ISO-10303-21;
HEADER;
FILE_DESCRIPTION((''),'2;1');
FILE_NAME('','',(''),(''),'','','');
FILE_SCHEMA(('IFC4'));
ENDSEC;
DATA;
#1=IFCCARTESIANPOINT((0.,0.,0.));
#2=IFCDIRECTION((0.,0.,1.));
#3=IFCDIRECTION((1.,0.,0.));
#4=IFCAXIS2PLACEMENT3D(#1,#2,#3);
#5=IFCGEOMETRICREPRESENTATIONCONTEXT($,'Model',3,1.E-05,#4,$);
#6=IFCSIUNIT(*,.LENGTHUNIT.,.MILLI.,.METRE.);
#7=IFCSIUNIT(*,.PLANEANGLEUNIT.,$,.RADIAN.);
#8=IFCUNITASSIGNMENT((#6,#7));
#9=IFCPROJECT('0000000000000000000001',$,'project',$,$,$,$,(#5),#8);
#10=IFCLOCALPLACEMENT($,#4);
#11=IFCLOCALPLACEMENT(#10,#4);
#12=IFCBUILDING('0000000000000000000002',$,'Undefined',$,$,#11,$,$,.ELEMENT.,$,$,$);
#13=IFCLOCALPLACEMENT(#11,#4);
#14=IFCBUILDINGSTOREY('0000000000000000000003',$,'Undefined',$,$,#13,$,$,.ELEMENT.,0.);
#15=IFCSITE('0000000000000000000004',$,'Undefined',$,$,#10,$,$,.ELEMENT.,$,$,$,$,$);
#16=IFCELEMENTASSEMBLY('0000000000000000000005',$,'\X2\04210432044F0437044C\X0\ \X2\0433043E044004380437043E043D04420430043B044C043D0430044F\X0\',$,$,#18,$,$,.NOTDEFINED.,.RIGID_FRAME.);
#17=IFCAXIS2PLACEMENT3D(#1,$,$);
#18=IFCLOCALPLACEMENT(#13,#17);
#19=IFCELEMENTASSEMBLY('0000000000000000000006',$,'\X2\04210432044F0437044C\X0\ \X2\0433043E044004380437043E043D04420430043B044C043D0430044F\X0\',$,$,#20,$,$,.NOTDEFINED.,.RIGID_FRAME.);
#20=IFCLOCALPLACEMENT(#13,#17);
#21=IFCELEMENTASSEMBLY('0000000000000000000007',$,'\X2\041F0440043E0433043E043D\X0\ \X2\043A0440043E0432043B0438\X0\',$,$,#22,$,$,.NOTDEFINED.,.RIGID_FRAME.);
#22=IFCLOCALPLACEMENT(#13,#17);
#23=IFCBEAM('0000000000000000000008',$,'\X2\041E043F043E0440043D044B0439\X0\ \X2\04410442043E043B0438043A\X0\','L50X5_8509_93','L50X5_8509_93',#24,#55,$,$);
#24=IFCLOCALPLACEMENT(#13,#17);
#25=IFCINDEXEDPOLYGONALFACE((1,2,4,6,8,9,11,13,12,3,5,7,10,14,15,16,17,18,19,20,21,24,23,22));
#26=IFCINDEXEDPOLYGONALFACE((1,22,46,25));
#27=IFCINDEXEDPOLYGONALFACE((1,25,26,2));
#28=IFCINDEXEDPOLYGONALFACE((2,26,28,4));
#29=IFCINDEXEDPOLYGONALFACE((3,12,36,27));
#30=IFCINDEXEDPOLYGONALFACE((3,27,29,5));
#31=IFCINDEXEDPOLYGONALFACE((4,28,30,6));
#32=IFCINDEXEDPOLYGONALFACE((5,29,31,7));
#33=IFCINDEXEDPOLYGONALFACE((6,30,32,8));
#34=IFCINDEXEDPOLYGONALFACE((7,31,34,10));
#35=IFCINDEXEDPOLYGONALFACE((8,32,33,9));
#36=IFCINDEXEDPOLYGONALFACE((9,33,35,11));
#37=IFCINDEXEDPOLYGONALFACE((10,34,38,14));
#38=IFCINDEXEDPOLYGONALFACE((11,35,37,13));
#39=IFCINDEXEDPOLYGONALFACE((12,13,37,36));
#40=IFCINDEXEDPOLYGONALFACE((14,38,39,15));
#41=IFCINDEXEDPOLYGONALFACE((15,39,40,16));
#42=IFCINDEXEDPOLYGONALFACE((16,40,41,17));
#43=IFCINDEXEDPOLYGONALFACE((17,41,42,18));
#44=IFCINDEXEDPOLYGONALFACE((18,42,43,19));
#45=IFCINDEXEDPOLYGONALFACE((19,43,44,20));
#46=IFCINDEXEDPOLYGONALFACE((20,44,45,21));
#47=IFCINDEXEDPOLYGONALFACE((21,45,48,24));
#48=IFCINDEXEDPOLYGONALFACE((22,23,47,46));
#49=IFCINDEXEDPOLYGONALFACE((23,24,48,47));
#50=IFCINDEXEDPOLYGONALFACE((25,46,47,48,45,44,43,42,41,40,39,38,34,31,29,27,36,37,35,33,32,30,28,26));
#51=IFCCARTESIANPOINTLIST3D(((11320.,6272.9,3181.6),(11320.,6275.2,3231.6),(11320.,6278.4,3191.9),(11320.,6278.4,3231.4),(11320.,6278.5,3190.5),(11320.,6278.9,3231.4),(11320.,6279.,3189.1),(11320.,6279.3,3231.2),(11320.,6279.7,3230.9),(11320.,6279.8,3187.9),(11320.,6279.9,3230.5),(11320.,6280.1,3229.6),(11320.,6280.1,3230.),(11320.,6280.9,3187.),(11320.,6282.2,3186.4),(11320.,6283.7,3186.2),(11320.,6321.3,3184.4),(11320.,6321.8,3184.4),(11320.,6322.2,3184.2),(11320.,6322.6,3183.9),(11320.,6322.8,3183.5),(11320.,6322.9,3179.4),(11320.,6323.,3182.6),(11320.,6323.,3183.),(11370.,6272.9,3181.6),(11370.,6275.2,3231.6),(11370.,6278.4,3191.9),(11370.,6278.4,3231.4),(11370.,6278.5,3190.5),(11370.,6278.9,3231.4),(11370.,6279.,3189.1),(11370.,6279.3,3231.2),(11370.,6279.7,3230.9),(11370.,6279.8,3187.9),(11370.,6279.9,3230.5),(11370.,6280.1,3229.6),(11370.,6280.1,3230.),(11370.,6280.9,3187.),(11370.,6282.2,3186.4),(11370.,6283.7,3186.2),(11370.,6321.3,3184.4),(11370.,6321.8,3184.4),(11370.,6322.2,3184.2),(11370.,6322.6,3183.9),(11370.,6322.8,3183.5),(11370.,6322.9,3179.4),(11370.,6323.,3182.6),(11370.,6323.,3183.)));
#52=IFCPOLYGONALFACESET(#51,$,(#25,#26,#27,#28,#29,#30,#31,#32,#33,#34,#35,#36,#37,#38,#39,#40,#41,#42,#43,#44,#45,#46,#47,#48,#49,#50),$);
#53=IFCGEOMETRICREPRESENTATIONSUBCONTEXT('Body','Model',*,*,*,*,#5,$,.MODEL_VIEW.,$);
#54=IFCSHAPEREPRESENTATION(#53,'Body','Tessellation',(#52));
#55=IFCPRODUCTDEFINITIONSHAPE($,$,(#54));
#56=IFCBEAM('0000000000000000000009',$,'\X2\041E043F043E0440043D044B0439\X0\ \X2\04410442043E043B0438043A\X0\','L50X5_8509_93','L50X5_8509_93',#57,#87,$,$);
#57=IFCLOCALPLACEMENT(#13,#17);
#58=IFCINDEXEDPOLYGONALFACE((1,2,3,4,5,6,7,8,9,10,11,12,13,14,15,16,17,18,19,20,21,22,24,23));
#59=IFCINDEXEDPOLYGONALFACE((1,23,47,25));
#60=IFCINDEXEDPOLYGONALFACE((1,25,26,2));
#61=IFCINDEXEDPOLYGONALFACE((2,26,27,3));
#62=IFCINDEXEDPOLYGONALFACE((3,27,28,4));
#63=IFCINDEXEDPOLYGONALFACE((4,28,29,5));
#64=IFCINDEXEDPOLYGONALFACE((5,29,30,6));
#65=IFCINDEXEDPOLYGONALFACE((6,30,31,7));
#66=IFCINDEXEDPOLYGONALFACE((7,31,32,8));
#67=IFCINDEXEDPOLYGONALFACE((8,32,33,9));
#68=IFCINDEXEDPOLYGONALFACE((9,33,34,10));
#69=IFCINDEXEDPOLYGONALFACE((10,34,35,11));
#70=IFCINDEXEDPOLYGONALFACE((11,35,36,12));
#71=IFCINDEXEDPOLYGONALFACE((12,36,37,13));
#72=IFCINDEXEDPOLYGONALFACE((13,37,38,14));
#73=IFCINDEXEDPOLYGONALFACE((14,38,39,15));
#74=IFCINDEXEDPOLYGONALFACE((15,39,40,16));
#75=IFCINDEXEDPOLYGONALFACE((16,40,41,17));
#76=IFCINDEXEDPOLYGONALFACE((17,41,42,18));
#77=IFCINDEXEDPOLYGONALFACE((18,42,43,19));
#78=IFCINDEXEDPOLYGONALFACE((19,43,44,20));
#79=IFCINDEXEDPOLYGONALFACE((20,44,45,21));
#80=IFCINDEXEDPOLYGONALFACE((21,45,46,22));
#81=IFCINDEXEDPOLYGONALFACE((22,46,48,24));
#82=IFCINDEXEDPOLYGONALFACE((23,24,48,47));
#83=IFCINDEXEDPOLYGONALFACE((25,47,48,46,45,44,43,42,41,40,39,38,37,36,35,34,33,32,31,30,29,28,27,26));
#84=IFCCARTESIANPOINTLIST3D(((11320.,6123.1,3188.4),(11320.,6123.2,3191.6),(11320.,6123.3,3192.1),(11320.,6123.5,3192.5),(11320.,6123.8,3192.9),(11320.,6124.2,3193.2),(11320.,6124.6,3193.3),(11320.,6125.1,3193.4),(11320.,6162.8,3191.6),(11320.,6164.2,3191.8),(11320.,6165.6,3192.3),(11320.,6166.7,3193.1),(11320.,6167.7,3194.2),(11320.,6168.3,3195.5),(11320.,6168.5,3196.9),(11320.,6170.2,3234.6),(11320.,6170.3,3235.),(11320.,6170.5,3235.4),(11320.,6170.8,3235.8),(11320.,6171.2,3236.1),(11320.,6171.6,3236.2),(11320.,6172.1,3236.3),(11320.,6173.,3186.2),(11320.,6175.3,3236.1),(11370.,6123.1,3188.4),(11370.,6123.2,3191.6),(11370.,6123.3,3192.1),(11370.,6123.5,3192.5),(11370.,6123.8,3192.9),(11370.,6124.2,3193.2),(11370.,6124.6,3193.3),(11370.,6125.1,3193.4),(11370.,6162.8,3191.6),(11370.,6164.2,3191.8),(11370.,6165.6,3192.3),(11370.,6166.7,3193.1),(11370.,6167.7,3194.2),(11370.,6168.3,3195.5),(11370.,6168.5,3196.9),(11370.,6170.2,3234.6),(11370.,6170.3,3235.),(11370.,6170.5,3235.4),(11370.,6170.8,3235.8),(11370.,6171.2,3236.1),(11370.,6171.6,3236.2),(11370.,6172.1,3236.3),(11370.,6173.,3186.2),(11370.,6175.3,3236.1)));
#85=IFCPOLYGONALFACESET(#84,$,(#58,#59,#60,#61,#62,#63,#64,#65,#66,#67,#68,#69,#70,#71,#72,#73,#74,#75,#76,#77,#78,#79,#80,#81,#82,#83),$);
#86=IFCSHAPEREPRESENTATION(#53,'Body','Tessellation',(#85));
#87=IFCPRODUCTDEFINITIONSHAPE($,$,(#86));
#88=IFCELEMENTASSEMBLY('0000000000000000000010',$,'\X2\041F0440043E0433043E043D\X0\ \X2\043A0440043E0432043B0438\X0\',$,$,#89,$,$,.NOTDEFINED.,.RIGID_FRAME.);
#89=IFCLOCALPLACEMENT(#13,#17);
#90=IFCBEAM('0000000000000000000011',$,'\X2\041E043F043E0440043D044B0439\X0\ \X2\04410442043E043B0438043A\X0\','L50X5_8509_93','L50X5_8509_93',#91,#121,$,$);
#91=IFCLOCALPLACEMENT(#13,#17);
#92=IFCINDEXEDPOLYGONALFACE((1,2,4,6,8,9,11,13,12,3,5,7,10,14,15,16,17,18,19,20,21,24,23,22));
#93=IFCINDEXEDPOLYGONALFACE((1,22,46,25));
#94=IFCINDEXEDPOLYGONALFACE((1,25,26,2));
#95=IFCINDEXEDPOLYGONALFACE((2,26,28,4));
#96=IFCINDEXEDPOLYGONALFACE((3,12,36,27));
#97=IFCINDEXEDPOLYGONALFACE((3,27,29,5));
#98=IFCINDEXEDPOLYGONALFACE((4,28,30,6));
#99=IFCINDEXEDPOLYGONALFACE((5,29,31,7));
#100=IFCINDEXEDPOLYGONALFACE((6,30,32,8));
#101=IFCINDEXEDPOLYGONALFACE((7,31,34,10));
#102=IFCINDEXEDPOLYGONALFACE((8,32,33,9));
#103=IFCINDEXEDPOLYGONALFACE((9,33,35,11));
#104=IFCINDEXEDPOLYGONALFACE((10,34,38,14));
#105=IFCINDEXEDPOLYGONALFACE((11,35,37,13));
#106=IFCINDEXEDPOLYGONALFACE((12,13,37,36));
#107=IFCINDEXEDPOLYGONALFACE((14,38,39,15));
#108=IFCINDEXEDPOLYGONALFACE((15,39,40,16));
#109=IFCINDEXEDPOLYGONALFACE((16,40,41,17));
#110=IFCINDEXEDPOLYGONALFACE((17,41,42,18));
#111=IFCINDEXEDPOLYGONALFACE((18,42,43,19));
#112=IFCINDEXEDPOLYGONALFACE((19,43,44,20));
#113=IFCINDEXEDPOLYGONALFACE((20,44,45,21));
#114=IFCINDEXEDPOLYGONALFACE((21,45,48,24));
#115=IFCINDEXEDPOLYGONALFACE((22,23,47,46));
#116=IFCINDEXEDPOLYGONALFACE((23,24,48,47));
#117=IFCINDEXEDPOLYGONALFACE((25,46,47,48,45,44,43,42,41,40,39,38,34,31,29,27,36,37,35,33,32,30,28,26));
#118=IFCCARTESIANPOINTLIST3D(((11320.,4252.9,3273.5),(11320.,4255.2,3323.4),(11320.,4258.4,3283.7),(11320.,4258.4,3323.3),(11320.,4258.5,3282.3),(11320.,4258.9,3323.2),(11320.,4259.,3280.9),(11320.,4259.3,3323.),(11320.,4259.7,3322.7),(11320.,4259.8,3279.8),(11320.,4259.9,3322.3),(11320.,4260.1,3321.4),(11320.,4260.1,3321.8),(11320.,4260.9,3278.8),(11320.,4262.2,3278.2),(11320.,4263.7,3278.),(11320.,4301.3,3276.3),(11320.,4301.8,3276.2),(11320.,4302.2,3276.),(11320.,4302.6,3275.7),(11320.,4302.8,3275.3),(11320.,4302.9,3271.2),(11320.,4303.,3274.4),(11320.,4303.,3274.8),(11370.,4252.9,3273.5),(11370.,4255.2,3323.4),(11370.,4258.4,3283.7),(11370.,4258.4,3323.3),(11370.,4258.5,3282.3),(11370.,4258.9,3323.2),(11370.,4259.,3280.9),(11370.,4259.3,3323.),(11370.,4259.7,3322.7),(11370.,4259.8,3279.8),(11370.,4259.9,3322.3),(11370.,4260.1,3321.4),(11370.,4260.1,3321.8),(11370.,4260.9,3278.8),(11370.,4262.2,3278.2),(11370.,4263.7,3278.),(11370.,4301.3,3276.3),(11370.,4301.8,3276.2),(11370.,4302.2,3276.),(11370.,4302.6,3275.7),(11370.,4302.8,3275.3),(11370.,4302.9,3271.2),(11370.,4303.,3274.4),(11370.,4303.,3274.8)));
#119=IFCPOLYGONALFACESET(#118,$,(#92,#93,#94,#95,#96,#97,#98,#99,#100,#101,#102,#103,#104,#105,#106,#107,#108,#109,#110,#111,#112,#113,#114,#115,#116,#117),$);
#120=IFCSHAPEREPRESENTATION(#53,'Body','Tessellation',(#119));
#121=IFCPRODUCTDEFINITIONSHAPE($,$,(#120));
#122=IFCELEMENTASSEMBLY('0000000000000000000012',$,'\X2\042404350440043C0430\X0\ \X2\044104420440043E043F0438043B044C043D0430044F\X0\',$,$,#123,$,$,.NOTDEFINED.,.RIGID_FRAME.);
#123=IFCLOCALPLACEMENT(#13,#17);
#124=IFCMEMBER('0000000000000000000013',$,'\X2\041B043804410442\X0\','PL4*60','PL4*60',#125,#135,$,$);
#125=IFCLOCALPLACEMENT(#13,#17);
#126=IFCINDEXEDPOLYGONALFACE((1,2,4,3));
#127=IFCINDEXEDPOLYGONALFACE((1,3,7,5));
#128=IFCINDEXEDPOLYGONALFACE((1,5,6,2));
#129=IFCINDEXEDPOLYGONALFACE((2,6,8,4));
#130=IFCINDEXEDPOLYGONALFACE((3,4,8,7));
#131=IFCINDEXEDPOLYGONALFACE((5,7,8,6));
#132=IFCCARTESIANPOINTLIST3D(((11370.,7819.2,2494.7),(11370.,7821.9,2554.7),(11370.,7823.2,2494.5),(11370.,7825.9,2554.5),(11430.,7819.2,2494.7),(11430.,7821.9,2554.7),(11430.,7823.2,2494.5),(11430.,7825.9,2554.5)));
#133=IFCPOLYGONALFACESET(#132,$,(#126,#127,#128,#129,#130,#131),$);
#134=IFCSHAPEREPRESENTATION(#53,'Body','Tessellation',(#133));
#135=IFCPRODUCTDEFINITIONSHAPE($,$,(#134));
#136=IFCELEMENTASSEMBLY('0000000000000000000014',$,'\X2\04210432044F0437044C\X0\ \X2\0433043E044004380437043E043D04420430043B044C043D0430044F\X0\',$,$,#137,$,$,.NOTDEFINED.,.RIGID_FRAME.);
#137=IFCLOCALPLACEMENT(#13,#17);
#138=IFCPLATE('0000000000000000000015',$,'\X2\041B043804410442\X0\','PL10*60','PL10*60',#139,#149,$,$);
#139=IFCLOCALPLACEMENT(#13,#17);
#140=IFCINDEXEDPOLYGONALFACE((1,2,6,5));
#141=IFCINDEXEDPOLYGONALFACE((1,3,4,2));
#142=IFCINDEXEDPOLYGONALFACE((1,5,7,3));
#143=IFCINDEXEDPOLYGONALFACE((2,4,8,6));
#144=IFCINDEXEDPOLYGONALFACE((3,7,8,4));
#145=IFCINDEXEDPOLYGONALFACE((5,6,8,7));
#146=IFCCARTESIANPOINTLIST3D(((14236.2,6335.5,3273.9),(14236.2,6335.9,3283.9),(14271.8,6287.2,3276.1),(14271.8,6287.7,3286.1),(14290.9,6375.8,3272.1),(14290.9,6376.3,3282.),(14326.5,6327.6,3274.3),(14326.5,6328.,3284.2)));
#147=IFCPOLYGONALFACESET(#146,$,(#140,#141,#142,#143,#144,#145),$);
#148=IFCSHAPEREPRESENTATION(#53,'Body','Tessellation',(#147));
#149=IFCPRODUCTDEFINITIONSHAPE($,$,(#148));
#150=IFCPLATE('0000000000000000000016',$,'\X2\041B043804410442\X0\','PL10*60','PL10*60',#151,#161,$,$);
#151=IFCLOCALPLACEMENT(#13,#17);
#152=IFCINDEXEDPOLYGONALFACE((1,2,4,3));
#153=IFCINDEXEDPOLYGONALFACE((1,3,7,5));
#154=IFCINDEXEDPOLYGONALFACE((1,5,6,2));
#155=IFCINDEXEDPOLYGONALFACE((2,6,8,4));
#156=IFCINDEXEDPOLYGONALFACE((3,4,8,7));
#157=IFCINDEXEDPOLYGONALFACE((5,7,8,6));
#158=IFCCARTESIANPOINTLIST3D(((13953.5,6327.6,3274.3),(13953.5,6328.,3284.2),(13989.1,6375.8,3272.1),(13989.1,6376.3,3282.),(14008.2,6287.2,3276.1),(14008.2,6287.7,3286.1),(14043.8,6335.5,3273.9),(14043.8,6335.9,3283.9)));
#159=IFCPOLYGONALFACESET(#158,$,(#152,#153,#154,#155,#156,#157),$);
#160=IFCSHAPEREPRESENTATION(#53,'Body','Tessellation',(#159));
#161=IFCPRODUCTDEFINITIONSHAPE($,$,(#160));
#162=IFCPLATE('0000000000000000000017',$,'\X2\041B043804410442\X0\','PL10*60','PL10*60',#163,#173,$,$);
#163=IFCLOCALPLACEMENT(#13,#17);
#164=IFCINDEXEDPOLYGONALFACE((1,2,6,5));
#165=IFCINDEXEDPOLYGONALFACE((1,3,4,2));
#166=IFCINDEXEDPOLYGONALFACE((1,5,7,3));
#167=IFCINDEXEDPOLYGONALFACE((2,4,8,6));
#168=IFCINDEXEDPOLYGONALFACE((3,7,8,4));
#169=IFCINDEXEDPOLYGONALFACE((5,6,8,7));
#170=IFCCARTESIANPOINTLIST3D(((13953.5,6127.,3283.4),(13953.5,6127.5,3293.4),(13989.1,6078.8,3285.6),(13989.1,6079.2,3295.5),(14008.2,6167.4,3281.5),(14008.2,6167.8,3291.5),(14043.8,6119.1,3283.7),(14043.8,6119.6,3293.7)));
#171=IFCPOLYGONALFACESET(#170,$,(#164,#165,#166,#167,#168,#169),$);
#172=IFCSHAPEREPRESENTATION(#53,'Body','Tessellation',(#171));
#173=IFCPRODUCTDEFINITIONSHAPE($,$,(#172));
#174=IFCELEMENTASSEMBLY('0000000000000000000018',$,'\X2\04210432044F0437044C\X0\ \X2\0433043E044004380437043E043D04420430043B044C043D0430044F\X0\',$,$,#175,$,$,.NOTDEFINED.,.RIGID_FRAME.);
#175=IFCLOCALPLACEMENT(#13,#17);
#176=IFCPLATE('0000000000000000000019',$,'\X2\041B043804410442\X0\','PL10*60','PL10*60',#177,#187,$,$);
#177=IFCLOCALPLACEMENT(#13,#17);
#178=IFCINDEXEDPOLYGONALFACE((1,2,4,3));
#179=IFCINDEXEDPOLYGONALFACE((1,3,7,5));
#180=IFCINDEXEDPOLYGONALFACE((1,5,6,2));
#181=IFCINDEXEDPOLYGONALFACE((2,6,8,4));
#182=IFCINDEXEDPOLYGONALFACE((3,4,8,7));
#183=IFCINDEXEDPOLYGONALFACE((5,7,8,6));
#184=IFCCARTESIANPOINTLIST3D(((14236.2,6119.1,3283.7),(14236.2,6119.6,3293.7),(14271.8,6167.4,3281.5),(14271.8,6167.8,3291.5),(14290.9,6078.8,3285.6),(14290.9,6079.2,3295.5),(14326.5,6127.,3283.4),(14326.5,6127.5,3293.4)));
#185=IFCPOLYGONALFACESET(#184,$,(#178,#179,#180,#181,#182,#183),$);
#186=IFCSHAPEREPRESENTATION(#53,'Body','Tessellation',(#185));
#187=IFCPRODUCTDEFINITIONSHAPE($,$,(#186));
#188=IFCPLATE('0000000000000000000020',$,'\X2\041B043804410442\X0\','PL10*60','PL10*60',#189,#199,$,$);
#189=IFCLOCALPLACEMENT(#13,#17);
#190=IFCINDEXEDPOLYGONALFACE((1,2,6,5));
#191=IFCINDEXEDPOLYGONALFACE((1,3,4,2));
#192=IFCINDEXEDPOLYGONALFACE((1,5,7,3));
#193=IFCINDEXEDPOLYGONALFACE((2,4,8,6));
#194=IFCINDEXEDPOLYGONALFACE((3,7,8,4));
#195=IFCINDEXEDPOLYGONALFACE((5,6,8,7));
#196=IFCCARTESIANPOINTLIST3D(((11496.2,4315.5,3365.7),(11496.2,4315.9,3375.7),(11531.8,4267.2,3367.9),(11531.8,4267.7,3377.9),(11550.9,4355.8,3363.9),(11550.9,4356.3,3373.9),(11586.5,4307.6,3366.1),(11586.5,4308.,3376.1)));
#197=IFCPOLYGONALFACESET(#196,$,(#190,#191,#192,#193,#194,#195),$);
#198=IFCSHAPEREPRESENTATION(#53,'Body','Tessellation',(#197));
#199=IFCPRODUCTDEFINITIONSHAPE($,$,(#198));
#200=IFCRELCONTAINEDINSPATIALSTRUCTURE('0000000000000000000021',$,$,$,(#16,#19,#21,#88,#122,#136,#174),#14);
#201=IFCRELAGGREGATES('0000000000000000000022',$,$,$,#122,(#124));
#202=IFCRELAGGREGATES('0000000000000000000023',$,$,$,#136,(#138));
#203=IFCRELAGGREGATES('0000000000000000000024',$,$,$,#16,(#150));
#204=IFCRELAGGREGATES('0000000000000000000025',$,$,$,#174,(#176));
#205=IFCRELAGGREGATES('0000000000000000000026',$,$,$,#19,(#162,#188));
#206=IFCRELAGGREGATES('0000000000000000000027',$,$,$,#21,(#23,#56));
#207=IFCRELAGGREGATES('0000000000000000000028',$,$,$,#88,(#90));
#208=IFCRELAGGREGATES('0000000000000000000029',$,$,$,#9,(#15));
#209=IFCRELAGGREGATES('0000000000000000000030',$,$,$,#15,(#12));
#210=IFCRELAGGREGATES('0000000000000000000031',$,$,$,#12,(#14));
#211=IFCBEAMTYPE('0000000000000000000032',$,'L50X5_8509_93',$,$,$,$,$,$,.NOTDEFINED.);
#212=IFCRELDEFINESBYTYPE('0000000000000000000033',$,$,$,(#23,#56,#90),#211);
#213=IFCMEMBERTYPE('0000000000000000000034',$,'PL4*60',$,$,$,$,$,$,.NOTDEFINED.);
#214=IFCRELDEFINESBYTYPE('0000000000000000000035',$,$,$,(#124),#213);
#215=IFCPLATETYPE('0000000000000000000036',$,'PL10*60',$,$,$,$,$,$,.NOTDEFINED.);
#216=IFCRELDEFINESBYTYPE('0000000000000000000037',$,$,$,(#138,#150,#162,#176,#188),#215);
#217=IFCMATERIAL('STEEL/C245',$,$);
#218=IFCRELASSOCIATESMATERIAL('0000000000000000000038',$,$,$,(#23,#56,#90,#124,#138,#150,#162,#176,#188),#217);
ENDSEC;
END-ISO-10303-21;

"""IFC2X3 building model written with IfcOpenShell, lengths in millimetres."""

from ifc_helpers import new_model, si_unit, frame, origin_with_axes, origin_2d_with_axis, place, context, subcontext, project, spatial, polyline, rectangle, l_section, outline, extrude, material, type_object, element, aggregate, save


model = new_model("IFC2X3")

# Units and contexts
model_context = context("Model", 3, precision=1e-05, world=origin_with_axes())
body_context = subcontext(model_context, "Body", "Model", "MODEL_VIEW")
ifc_project = project(units=[si_unit("LENGTHUNIT", "METRE", prefix="MILLI"), si_unit("PLANEANGLEUNIT", "RADIAN")], contexts=[model_context])

# Site, building, storey
site_placement = place(None, origin_with_axes())
site = spatial("IfcSite", under=ifc_project, at=site_placement, Name="Undefined", CompositionType="ELEMENT")
building_placement = place(site_placement, origin_with_axes())
building = spatial("IfcBuilding", under=site, at=building_placement, Name="Undefined", CompositionType="ELEMENT")
storey_placement = place(building_placement, origin_with_axes())
storey = spatial("IfcBuildingStorey", under=building, at=storey_placement, Name="Undefined", CompositionType="ELEMENT", Elevation=0.0)

# Element assembly
assembly_1_placement = place(storey_placement, origin_with_axes())
assembly_1 = element("IfcElementAssembly", 1, at=assembly_1_placement, inside=storey, Name="Связь горизонтальная", AssemblyPlace="NOTDEFINED", PredefinedType="RIGID_FRAME")
ifc_material_1 = material(Name="STEEL/C245")

# Element assembly
assembly_2_placement = place(storey_placement, origin_with_axes())
assembly_2 = element("IfcElementAssembly", 2, at=assembly_2_placement, inside=storey, Name="Связь горизонтальная", AssemblyPlace="NOTDEFINED", PredefinedType="RIGID_FRAME")

# Element assembly
assembly_3_placement = place(storey_placement, origin_with_axes())
assembly_3 = element("IfcElementAssembly", 3, at=assembly_3_placement, inside=storey, Name="Прогон кровли", AssemblyPlace="NOTDEFINED", PredefinedType="RIGID_FRAME")

# Shared definitions
beam_type = type_object("IfcBeamType", Name="L50X5_8509_93", PredefinedType="NOTDEFINED")

# Beams
beam_1_placement = place(assembly_3_placement, frame((11320.0, 6299.0, 3205.5), z_axis=(0.0, 0.998969, -0.045408), x_axis=(1.0, 0.0, 0.0)))
beam_1 = element("IfcBeam", 4, at=beam_1_placement, type_object=beam_type, material=ifc_material_1, Name="Опорный столик", Description="L50X5_8509_93", ObjectType="L50X5_8509_93", context=body_context, shape_type="SweptSolid", body=[
    extrude(l_section(Depth=50.0, Width=50.0, Thickness=5.0, FilletRadius=5.5, EdgeRadius=1.8, at=origin_2d_with_axis()), frame((50.0, 0.0, 0.0), z_axis=(-1.0, 0.0, 0.0), x_axis=(0.0, -1.0, 0.0)), (0.0, 0.0, 1.0), 50.0),
])
beam_2_placement = place(assembly_3_placement, frame((11370.0, 6149.2, 3212.3), z_axis=(0.0, -0.998969, 0.045408), x_axis=(-1.0, 0.0, 0.0)))
beam_2 = element("IfcBeam", 5, at=beam_2_placement, type_object=beam_type, material=ifc_material_1, Name="Опорный столик", Description="L50X5_8509_93", ObjectType="L50X5_8509_93", context=body_context, shape_type="SweptSolid", body=[
    extrude(l_section(Depth=50.0, Width=50.0, Thickness=5.0, FilletRadius=5.5, EdgeRadius=1.8, at=origin_2d_with_axis()), frame((50.0, 0.0, 0.0), z_axis=(-1.0, 0.0, 0.0), x_axis=(0.0, -1.0, 0.0)), (0.0, 0.0, 1.0), 50.0),
])

# Element assembly, beam
assembly_4_placement = place(storey_placement, origin_with_axes())
assembly_4 = element("IfcElementAssembly", 6, at=assembly_4_placement, inside=storey, Name="Прогон кровли", AssemblyPlace="NOTDEFINED", PredefinedType="RIGID_FRAME")
beam_3_placement = place(assembly_4_placement, frame((11320.0, 4279.1, 3297.3), z_axis=(0.0, 0.998969, -0.045408), x_axis=(1.0, 0.0, 0.0)))
beam_3 = element("IfcBeam", 7, at=beam_3_placement, type_object=beam_type, material=ifc_material_1, Name="Опорный столик", Description="L50X5_8509_93", ObjectType="L50X5_8509_93", context=body_context, shape_type="SweptSolid", body=[
    extrude(l_section(Depth=50.0, Width=50.0, Thickness=5.0, FilletRadius=5.5, EdgeRadius=1.8, at=origin_2d_with_axis()), frame((50.0, 0.0, 0.0), z_axis=(-1.0, 0.0, 0.0), x_axis=(0.0, -1.0, 0.0)), (0.0, 0.0, 1.0), 50.0),
])

# Element assembly, member
assembly_5_placement = place(storey_placement, origin_with_axes())
assembly_5 = element("IfcElementAssembly", 8, at=assembly_5_placement, inside=storey, Name="Ферма стропильная", AssemblyPlace="NOTDEFINED", PredefinedType="RIGID_FRAME")
member_type_1 = type_object("IfcMemberType", Name="PL4*60", PredefinedType="NOTDEFINED")
member_1_placement = place(assembly_5_placement, frame((11400.0, 7821.2, 2494.6), z_axis=(-1.0, 0.0, 0.0), x_axis=(0.0, 0.045408, 0.998969)))
member_1 = element("IfcMember", 9, at=member_1_placement, type_object=member_type_1, material=ifc_material_1, Name="Лист", Description="PL4*60", ObjectType="PL4*60", context=body_context, shape_type="SweptSolid", body=[
    extrude(rectangle(XDim=4.0, YDim=60.0, at=origin_2d_with_axis()), frame((60.0, 0.0, 0.0), z_axis=(-1.0, 0.0, 0.0), x_axis=(0.0, -1.0, 0.0)), (0.0, 0.0, 1.0), 60.0),
])

# Element assembly, plate
assembly_6_placement = place(storey_placement, origin_with_axes())
assembly_6 = element("IfcElementAssembly", 10, at=assembly_6_placement, inside=storey, Name="Связь горизонтальная", AssemblyPlace="NOTDEFINED", PredefinedType="RIGID_FRAME")
plate_type_1 = type_object("IfcPlateType", Name="PL10*60", PredefinedType="NOTDEFINED")
plate_1_placement = place(assembly_6_placement, frame((14254.0, 6311.6, 3280.0), z_axis=(0.0, -0.045408, -0.998969), x_axis=(0.804616, 0.593183, -0.026963)))
plate_1 = element("IfcPlate", 11, at=plate_1_placement, type_object=plate_type_1, material=ifc_material_1, Name="Лист", Description="PL10*60", ObjectType="PL10*60", context=body_context, shape_type="SweptSolid", body=[
    extrude(outline(polyline([(0.0, -30.0), (0.0, 30.0), (68.0, 30.0), (68.0, -30.0), (0.0, -30.0)])), frame((0.0, 0.0, -5.0), z_axis=(0.0, 0.0, 1.0), x_axis=(1.0, 0.0, 0.0)), (0.0, 0.0, 1.0), 10.0),
])

# Plates
plate_2_placement = place(assembly_1_placement, frame((14026.0, 6311.6, 3280.0), z_axis=(0.0, -0.045408, -0.998969), x_axis=(-0.804616, 0.593183, -0.026963)))
plate_2 = element("IfcPlate", 12, at=plate_2_placement, type_object=plate_type_1, material=ifc_material_1, Name="Лист", Description="PL10*60", ObjectType="PL10*60", context=body_context, shape_type="SweptSolid", body=[
    extrude(outline(polyline([(68.0, -30.0), (0.0, -30.0), (0.0, 30.0), (68.0, 30.0), (68.0, -30.0)])), frame((0.0, 0.0, -5.0), z_axis=(0.0, 0.0, 1.0), x_axis=(1.0, 0.0, 0.0)), (0.0, 0.0, 1.0), 10.0),
])
plate_3_placement = place(assembly_2_placement, frame((14026.0, 6143.5, 3287.6), z_axis=(0.0, -0.045408, -0.998969), x_axis=(-0.804616, -0.593183, 0.026963)))
plate_3 = element("IfcPlate", 13, at=plate_3_placement, type_object=plate_type_1, material=ifc_material_1, Name="Лист", Description="PL10*60", ObjectType="PL10*60", context=body_context, shape_type="SweptSolid", body=[
    extrude(outline(polyline([(68.0, 30.0), (68.0, -30.0), (0.0, -30.0), (0.0, 30.0), (68.0, 30.0)])), frame((0.0, 0.0, -5.0), z_axis=(0.0, 0.0, 1.0), x_axis=(1.0, 0.0, 0.0)), (0.0, 0.0, 1.0), 10.0),
])

# Element assembly, plate
assembly_7_placement = place(storey_placement, origin_with_axes())
assembly_7 = element("IfcElementAssembly", 14, at=assembly_7_placement, inside=storey, Name="Связь горизонтальная", AssemblyPlace="NOTDEFINED", PredefinedType="RIGID_FRAME")
plate_4_placement = place(assembly_7_placement, frame((14254.0, 6143.5, 3287.6), z_axis=(0.0, -0.045408, -0.998969), x_axis=(0.804616, -0.593183, 0.026963)))
plate_4 = element("IfcPlate", 15, at=plate_4_placement, type_object=plate_type_1, material=ifc_material_1, Name="Лист", Description="PL10*60", ObjectType="PL10*60", context=body_context, shape_type="SweptSolid", body=[
    extrude(outline(polyline([(0.0, 30.0), (68.0, 30.0), (68.0, -30.0), (0.0, -30.0), (0.0, 30.0)])), frame((0.0, 0.0, -5.0), z_axis=(0.0, 0.0, 1.0), x_axis=(1.0, 0.0, 0.0)), (0.0, 0.0, 1.0), 10.0),
])

# Plate
plate_5_placement = place(assembly_2_placement, frame((11514.0, 4291.6, 3371.8), z_axis=(0.0, -0.045408, -0.998969), x_axis=(0.804616, 0.593183, -0.026963)))
plate_5 = element("IfcPlate", 16, at=plate_5_placement, type_object=plate_type_1, material=ifc_material_1, Name="Лист", Description="PL10*60", ObjectType="PL10*60", context=body_context, shape_type="SweptSolid", body=[
    extrude(outline(polyline([(0.0, -30.0), (0.0, 30.0), (68.0, 30.0), (68.0, -30.0), (0.0, -30.0)])), frame((0.0, 0.0, -5.0), z_axis=(0.0, 0.0, 1.0), x_axis=(1.0, 0.0, 0.0)), (0.0, 0.0, 1.0), 10.0),
])
aggregate(assembly_5, [member_1])

aggregate(assembly_6, [plate_1])
aggregate(assembly_1, [plate_2])
aggregate(assembly_7, [plate_4])
aggregate(assembly_2, [plate_3, plate_5])
aggregate(assembly_3, [beam_1, beam_2])
aggregate(assembly_4, [beam_3])

save(model, "model.ifc")
